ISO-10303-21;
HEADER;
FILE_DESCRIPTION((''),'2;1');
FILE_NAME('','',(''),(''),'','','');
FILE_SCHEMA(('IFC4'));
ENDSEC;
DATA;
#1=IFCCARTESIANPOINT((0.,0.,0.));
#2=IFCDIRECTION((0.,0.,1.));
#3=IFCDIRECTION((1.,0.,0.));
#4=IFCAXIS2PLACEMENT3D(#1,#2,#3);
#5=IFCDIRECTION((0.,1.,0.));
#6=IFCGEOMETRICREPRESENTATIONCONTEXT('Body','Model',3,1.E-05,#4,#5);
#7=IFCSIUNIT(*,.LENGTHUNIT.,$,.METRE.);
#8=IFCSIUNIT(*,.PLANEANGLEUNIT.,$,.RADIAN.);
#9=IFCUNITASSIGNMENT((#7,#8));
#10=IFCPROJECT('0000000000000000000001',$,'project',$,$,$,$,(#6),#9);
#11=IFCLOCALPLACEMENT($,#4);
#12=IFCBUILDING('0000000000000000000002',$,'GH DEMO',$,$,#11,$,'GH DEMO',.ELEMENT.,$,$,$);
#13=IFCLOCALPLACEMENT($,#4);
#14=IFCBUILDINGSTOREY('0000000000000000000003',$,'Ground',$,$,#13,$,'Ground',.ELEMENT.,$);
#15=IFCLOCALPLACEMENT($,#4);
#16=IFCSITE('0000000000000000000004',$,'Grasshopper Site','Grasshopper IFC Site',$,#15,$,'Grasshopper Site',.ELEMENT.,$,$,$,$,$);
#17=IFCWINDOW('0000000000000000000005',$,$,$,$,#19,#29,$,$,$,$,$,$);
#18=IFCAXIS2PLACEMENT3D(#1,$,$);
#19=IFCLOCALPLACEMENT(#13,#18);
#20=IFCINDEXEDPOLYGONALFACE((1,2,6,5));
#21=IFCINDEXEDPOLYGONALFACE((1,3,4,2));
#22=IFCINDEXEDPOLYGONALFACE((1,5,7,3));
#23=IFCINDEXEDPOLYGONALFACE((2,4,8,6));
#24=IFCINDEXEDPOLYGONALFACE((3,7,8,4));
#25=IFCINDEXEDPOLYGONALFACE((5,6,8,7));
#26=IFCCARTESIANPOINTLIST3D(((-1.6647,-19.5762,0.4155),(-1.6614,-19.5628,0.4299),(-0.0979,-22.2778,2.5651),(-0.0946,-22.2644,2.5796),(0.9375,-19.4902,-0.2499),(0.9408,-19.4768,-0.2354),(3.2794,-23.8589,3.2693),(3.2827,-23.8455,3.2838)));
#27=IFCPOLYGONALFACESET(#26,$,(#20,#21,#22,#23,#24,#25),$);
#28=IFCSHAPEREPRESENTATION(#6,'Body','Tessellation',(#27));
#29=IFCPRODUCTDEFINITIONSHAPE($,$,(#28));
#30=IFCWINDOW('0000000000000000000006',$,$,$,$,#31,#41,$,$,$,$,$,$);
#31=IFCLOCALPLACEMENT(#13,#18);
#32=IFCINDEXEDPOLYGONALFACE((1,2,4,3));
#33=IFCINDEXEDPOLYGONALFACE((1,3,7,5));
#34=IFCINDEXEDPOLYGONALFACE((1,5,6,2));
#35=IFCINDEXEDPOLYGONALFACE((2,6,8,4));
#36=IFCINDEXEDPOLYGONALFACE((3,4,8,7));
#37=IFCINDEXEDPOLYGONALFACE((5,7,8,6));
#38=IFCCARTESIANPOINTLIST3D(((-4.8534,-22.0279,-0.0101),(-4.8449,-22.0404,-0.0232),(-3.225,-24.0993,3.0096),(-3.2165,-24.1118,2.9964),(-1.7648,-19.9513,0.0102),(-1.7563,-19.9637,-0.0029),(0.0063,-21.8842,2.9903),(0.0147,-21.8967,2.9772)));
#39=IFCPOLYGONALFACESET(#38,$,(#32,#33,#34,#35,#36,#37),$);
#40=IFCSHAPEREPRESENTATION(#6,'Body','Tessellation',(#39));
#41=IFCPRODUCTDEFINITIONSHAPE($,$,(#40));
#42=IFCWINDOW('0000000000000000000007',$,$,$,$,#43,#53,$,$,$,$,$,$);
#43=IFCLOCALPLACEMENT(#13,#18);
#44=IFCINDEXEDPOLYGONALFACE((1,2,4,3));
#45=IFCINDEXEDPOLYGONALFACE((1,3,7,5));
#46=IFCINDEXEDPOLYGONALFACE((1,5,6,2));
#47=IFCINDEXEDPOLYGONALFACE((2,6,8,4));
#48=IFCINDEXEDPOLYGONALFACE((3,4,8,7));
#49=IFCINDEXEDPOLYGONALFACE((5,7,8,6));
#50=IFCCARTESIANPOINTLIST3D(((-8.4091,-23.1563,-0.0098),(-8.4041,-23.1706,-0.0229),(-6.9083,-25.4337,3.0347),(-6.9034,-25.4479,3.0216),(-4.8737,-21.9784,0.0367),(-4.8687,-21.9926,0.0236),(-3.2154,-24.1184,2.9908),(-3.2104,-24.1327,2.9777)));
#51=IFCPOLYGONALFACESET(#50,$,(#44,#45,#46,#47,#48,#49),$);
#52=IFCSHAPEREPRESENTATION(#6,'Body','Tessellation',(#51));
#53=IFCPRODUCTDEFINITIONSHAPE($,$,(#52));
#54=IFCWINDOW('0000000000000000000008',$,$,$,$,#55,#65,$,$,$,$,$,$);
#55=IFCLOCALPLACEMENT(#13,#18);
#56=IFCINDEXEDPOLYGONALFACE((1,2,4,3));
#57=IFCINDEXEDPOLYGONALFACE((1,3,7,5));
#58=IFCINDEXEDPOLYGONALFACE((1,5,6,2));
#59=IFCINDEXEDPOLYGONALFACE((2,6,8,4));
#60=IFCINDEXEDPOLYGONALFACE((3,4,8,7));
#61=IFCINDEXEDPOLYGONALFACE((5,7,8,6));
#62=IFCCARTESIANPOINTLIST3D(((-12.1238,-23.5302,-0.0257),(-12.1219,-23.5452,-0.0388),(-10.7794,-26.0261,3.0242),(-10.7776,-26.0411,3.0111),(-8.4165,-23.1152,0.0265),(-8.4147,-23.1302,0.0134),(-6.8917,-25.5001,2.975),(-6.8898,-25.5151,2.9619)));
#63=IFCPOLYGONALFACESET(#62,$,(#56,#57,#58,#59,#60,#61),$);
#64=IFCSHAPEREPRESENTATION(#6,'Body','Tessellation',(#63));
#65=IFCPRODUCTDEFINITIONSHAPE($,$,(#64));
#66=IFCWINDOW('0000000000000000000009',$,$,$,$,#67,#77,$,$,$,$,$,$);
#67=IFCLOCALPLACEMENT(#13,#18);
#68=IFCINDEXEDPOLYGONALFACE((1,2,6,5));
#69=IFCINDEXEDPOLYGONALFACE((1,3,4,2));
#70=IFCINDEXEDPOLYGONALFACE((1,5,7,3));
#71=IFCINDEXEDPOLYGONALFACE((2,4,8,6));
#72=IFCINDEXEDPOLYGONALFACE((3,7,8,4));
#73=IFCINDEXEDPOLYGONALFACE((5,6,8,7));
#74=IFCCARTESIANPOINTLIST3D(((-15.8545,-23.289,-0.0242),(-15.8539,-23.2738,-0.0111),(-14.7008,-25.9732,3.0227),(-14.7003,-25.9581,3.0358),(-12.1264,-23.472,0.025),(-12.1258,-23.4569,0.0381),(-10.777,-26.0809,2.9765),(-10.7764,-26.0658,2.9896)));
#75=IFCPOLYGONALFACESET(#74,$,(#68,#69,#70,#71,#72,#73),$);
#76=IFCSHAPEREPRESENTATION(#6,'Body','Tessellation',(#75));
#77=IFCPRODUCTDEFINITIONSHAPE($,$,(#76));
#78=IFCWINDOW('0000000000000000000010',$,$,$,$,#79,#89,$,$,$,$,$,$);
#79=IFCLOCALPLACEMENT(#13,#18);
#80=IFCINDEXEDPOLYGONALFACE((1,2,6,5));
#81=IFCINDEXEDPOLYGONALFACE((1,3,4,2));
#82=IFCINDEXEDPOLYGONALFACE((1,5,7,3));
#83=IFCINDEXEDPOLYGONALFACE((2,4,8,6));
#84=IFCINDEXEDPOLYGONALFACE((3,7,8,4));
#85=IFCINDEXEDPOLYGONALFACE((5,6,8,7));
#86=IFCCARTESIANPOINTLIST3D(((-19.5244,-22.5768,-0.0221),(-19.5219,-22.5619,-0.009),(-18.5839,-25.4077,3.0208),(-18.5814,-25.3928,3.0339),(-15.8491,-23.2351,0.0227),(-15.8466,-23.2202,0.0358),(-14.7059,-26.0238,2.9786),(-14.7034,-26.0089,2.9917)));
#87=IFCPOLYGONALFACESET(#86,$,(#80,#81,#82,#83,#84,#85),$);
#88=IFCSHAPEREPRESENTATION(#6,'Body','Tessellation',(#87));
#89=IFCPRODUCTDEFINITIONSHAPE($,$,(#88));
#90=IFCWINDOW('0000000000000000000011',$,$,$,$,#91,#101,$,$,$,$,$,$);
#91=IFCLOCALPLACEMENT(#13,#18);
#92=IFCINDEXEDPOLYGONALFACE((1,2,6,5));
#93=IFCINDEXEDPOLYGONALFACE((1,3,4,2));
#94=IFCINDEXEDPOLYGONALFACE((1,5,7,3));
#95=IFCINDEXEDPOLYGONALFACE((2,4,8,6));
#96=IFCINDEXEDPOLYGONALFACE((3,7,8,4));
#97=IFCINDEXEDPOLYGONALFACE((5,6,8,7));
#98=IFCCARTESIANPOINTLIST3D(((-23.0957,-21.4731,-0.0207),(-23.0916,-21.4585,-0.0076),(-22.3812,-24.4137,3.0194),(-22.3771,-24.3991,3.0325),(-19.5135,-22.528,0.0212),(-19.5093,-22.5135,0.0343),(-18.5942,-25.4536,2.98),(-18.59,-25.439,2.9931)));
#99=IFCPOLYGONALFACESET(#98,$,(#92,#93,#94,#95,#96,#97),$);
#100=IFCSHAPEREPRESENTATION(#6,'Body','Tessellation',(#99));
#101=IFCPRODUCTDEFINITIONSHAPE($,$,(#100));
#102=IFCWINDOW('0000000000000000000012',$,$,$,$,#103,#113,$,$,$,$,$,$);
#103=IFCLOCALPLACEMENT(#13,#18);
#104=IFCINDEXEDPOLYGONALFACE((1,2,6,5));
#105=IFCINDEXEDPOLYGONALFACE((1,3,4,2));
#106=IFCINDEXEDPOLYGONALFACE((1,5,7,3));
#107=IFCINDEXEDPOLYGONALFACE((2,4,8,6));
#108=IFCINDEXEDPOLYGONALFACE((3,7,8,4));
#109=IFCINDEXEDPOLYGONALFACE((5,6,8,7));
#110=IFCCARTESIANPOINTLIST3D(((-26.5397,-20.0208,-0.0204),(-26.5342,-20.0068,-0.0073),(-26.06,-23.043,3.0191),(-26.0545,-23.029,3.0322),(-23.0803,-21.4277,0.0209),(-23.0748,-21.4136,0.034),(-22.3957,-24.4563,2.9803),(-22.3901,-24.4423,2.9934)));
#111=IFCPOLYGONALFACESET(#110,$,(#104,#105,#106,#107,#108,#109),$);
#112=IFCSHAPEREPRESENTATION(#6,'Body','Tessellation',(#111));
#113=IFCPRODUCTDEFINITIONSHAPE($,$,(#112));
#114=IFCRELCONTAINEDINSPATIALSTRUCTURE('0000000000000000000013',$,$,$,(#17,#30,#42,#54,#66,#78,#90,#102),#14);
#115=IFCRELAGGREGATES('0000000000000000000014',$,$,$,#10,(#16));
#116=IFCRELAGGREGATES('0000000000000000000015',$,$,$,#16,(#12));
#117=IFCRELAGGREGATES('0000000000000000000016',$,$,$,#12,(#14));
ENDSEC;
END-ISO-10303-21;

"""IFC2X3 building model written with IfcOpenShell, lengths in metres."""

from ifc_helpers import new_model, si_unit, direction, frame, origin_with_axes, place, context, project, spatial, polyline, outline, extrude, element, save


model = new_model("IFC2X3")

# Units and contexts
model_context = context("Model", 3, precision=1e-05, world=origin_with_axes(), true_north=direction((0.0, 1.0, 0.0)), identifier="Body")
ifc_project = project(units=[si_unit("LENGTHUNIT", "METRE"), si_unit("PLANEANGLEUNIT", "RADIAN")], contexts=[model_context])

# Site, building, storey
site_placement = place(None, origin_with_axes())
site = spatial("IfcSite", under=ifc_project, at=site_placement, Name="Grasshopper Site", Description="Grasshopper IFC Site", LongName="Grasshopper Site", CompositionType="ELEMENT")
building_placement = place(None, origin_with_axes())
building = spatial("IfcBuilding", under=site, at=building_placement, Name="GH DEMO", LongName="GH DEMO", CompositionType="ELEMENT")
storey_placement = place(None, origin_with_axes())
storey = spatial("IfcBuildingStorey", under=building, at=storey_placement, Name="Ground", LongName="Ground", CompositionType="ELEMENT")

# Windows
window_1_placement = place(None, origin_with_axes())
element("IfcWindow", 1, at=window_1_placement, inside=storey, context=model_context, shape_type="SweptSolid", body=[
    extrude(outline(polyline([(0.0, 0.0), (6.0791, 0.0), (3.234, 2.5116), (-0.5555, 2.6292), (0.0, 0.0)])), frame((0.9375, -19.4902, -0.2499), z_axis=(-0.162925, -0.670437, -0.723858), x_axis=(0.385242, -0.718651, 0.578904)), (0.0, 0.0, -1.0), 0.02),
])
window_2_placement = place(None, origin_with_axes())
element("IfcWindow", 2, at=window_2_placement, inside=storey, context=model_context, shape_type="SweptSolid", body=[
    extrude(outline(polyline([(0.0, 0.0), (3.9691, 0.0), (3.6205, 3.9021), (-0.3821, 3.7022), (0.0, 0.0)])), frame((-1.7648, -19.9513, 0.0102), z_axis=(0.423819, -0.623938, -0.656566), x_axis=(0.446205, -0.486995, 0.750824)), (0.0, 0.0, 1.0), 0.02),
])
window_3_placement = place(None, origin_with_axes())
element("IfcWindow", 3, at=window_3_placement, inside=storey, context=model_context, shape_type="SweptSolid", body=[
    extrude(outline(polyline([(0.0, 0.0), (4.0071, 0.0), (3.2136, 3.8393), (-0.8683, 3.6242), (0.0, 0.0)])), frame((-4.8687, -21.9926, 0.0236), z_axis=(0.246456, -0.713864, -0.655483), x_axis=(0.41384, -0.534065, 0.737232)), (0.0, 0.0, -1.0), 0.02),
])
window_4_placement = place(None, origin_with_axes())
element("IfcWindow", 4, at=window_4_placement, inside=storey, context=model_context, shape_type="SweptSolid", body=[
    extrude(outline(polyline([(0.0, 0.0), (4.0873, 0.0), (2.9793, 3.7638), (-1.1786, 3.5397), (0.0, 0.0)])), frame((-8.4165, -23.1152, 0.0265), z_axis=(0.093182, -0.750002, -0.654839), x_axis=(0.37307, -0.583484, 0.721364)), (0.0, 0.0, 1.0), 0.02),
])
window_5_placement = place(None, origin_with_axes())
element("IfcWindow", 5, at=window_5_placement, inside=storey, context=model_context, shape_type="SweptSolid", body=[
    extrude(outline(polyline([(0.0, 0.0), (4.1639, 0.0), (2.8577, 3.7019), (-1.3577, 3.4773), (0.0, 0.0)])), frame((-12.1264, -23.472, 0.025), z_axis=(-0.028451, -0.755376, -0.654674), x_axis=(0.324054, -0.626538, 0.70883)), (0.0, 0.0, -1.0), 0.02),
])
window_6_placement = place(None, origin_with_axes())
element("IfcWindow", 6, at=window_6_placement, inside=storey, context=model_context, shape_type="SweptSolid", body=[
    extrude(outline(polyline([(0.0, 0.0), (4.2214, 0.0), (2.7939, 3.6581), (-1.4616, 3.4362), (0.0, 0.0)])), frame((-15.8491, -23.2351, 0.0227), z_axis=(-0.125531, -0.745402, -0.654689), x_axis=(0.270796, -0.660595, 0.700203)), (0.0, 0.0, -1.0), 0.02),
])
window_7_placement = place(None, origin_with_axes())
element("IfcWindow", 7, at=window_7_placement, inside=storey, context=model_context, shape_type="SweptSolid", body=[
    extrude(outline(polyline([(0.0, 0.0), (4.2613, 0.0), (2.7577, 3.6282), (-1.5262, 3.4085), (0.0, 0.0)])), frame((-19.5135, -22.528, 0.0212), z_axis=(-0.206466, -0.727086, -0.654765), x_axis=(0.215735, -0.686543, 0.694347)), (0.0, 0.0, -1.0), 0.02),
])
window_8_placement = place(None, origin_with_axes())
element("IfcWindow", 8, at=window_8_placement, inside=storey, context=model_context, shape_type="SweptSolid", body=[
    extrude(outline(polyline([(0.0, 0.0), (4.2895, 0.0), (2.7335, 3.6063), (-1.5739, 3.3869), (0.0, 0.0)])), frame((-23.0803, -21.4277, 0.0209), z_axis=(-0.277978, -0.702753, -0.654879), x_axis=(0.159614, -0.706062, 0.689927)), (0.0, 0.0, -1.0), 0.02),
])

save(model, "model.ifc")
